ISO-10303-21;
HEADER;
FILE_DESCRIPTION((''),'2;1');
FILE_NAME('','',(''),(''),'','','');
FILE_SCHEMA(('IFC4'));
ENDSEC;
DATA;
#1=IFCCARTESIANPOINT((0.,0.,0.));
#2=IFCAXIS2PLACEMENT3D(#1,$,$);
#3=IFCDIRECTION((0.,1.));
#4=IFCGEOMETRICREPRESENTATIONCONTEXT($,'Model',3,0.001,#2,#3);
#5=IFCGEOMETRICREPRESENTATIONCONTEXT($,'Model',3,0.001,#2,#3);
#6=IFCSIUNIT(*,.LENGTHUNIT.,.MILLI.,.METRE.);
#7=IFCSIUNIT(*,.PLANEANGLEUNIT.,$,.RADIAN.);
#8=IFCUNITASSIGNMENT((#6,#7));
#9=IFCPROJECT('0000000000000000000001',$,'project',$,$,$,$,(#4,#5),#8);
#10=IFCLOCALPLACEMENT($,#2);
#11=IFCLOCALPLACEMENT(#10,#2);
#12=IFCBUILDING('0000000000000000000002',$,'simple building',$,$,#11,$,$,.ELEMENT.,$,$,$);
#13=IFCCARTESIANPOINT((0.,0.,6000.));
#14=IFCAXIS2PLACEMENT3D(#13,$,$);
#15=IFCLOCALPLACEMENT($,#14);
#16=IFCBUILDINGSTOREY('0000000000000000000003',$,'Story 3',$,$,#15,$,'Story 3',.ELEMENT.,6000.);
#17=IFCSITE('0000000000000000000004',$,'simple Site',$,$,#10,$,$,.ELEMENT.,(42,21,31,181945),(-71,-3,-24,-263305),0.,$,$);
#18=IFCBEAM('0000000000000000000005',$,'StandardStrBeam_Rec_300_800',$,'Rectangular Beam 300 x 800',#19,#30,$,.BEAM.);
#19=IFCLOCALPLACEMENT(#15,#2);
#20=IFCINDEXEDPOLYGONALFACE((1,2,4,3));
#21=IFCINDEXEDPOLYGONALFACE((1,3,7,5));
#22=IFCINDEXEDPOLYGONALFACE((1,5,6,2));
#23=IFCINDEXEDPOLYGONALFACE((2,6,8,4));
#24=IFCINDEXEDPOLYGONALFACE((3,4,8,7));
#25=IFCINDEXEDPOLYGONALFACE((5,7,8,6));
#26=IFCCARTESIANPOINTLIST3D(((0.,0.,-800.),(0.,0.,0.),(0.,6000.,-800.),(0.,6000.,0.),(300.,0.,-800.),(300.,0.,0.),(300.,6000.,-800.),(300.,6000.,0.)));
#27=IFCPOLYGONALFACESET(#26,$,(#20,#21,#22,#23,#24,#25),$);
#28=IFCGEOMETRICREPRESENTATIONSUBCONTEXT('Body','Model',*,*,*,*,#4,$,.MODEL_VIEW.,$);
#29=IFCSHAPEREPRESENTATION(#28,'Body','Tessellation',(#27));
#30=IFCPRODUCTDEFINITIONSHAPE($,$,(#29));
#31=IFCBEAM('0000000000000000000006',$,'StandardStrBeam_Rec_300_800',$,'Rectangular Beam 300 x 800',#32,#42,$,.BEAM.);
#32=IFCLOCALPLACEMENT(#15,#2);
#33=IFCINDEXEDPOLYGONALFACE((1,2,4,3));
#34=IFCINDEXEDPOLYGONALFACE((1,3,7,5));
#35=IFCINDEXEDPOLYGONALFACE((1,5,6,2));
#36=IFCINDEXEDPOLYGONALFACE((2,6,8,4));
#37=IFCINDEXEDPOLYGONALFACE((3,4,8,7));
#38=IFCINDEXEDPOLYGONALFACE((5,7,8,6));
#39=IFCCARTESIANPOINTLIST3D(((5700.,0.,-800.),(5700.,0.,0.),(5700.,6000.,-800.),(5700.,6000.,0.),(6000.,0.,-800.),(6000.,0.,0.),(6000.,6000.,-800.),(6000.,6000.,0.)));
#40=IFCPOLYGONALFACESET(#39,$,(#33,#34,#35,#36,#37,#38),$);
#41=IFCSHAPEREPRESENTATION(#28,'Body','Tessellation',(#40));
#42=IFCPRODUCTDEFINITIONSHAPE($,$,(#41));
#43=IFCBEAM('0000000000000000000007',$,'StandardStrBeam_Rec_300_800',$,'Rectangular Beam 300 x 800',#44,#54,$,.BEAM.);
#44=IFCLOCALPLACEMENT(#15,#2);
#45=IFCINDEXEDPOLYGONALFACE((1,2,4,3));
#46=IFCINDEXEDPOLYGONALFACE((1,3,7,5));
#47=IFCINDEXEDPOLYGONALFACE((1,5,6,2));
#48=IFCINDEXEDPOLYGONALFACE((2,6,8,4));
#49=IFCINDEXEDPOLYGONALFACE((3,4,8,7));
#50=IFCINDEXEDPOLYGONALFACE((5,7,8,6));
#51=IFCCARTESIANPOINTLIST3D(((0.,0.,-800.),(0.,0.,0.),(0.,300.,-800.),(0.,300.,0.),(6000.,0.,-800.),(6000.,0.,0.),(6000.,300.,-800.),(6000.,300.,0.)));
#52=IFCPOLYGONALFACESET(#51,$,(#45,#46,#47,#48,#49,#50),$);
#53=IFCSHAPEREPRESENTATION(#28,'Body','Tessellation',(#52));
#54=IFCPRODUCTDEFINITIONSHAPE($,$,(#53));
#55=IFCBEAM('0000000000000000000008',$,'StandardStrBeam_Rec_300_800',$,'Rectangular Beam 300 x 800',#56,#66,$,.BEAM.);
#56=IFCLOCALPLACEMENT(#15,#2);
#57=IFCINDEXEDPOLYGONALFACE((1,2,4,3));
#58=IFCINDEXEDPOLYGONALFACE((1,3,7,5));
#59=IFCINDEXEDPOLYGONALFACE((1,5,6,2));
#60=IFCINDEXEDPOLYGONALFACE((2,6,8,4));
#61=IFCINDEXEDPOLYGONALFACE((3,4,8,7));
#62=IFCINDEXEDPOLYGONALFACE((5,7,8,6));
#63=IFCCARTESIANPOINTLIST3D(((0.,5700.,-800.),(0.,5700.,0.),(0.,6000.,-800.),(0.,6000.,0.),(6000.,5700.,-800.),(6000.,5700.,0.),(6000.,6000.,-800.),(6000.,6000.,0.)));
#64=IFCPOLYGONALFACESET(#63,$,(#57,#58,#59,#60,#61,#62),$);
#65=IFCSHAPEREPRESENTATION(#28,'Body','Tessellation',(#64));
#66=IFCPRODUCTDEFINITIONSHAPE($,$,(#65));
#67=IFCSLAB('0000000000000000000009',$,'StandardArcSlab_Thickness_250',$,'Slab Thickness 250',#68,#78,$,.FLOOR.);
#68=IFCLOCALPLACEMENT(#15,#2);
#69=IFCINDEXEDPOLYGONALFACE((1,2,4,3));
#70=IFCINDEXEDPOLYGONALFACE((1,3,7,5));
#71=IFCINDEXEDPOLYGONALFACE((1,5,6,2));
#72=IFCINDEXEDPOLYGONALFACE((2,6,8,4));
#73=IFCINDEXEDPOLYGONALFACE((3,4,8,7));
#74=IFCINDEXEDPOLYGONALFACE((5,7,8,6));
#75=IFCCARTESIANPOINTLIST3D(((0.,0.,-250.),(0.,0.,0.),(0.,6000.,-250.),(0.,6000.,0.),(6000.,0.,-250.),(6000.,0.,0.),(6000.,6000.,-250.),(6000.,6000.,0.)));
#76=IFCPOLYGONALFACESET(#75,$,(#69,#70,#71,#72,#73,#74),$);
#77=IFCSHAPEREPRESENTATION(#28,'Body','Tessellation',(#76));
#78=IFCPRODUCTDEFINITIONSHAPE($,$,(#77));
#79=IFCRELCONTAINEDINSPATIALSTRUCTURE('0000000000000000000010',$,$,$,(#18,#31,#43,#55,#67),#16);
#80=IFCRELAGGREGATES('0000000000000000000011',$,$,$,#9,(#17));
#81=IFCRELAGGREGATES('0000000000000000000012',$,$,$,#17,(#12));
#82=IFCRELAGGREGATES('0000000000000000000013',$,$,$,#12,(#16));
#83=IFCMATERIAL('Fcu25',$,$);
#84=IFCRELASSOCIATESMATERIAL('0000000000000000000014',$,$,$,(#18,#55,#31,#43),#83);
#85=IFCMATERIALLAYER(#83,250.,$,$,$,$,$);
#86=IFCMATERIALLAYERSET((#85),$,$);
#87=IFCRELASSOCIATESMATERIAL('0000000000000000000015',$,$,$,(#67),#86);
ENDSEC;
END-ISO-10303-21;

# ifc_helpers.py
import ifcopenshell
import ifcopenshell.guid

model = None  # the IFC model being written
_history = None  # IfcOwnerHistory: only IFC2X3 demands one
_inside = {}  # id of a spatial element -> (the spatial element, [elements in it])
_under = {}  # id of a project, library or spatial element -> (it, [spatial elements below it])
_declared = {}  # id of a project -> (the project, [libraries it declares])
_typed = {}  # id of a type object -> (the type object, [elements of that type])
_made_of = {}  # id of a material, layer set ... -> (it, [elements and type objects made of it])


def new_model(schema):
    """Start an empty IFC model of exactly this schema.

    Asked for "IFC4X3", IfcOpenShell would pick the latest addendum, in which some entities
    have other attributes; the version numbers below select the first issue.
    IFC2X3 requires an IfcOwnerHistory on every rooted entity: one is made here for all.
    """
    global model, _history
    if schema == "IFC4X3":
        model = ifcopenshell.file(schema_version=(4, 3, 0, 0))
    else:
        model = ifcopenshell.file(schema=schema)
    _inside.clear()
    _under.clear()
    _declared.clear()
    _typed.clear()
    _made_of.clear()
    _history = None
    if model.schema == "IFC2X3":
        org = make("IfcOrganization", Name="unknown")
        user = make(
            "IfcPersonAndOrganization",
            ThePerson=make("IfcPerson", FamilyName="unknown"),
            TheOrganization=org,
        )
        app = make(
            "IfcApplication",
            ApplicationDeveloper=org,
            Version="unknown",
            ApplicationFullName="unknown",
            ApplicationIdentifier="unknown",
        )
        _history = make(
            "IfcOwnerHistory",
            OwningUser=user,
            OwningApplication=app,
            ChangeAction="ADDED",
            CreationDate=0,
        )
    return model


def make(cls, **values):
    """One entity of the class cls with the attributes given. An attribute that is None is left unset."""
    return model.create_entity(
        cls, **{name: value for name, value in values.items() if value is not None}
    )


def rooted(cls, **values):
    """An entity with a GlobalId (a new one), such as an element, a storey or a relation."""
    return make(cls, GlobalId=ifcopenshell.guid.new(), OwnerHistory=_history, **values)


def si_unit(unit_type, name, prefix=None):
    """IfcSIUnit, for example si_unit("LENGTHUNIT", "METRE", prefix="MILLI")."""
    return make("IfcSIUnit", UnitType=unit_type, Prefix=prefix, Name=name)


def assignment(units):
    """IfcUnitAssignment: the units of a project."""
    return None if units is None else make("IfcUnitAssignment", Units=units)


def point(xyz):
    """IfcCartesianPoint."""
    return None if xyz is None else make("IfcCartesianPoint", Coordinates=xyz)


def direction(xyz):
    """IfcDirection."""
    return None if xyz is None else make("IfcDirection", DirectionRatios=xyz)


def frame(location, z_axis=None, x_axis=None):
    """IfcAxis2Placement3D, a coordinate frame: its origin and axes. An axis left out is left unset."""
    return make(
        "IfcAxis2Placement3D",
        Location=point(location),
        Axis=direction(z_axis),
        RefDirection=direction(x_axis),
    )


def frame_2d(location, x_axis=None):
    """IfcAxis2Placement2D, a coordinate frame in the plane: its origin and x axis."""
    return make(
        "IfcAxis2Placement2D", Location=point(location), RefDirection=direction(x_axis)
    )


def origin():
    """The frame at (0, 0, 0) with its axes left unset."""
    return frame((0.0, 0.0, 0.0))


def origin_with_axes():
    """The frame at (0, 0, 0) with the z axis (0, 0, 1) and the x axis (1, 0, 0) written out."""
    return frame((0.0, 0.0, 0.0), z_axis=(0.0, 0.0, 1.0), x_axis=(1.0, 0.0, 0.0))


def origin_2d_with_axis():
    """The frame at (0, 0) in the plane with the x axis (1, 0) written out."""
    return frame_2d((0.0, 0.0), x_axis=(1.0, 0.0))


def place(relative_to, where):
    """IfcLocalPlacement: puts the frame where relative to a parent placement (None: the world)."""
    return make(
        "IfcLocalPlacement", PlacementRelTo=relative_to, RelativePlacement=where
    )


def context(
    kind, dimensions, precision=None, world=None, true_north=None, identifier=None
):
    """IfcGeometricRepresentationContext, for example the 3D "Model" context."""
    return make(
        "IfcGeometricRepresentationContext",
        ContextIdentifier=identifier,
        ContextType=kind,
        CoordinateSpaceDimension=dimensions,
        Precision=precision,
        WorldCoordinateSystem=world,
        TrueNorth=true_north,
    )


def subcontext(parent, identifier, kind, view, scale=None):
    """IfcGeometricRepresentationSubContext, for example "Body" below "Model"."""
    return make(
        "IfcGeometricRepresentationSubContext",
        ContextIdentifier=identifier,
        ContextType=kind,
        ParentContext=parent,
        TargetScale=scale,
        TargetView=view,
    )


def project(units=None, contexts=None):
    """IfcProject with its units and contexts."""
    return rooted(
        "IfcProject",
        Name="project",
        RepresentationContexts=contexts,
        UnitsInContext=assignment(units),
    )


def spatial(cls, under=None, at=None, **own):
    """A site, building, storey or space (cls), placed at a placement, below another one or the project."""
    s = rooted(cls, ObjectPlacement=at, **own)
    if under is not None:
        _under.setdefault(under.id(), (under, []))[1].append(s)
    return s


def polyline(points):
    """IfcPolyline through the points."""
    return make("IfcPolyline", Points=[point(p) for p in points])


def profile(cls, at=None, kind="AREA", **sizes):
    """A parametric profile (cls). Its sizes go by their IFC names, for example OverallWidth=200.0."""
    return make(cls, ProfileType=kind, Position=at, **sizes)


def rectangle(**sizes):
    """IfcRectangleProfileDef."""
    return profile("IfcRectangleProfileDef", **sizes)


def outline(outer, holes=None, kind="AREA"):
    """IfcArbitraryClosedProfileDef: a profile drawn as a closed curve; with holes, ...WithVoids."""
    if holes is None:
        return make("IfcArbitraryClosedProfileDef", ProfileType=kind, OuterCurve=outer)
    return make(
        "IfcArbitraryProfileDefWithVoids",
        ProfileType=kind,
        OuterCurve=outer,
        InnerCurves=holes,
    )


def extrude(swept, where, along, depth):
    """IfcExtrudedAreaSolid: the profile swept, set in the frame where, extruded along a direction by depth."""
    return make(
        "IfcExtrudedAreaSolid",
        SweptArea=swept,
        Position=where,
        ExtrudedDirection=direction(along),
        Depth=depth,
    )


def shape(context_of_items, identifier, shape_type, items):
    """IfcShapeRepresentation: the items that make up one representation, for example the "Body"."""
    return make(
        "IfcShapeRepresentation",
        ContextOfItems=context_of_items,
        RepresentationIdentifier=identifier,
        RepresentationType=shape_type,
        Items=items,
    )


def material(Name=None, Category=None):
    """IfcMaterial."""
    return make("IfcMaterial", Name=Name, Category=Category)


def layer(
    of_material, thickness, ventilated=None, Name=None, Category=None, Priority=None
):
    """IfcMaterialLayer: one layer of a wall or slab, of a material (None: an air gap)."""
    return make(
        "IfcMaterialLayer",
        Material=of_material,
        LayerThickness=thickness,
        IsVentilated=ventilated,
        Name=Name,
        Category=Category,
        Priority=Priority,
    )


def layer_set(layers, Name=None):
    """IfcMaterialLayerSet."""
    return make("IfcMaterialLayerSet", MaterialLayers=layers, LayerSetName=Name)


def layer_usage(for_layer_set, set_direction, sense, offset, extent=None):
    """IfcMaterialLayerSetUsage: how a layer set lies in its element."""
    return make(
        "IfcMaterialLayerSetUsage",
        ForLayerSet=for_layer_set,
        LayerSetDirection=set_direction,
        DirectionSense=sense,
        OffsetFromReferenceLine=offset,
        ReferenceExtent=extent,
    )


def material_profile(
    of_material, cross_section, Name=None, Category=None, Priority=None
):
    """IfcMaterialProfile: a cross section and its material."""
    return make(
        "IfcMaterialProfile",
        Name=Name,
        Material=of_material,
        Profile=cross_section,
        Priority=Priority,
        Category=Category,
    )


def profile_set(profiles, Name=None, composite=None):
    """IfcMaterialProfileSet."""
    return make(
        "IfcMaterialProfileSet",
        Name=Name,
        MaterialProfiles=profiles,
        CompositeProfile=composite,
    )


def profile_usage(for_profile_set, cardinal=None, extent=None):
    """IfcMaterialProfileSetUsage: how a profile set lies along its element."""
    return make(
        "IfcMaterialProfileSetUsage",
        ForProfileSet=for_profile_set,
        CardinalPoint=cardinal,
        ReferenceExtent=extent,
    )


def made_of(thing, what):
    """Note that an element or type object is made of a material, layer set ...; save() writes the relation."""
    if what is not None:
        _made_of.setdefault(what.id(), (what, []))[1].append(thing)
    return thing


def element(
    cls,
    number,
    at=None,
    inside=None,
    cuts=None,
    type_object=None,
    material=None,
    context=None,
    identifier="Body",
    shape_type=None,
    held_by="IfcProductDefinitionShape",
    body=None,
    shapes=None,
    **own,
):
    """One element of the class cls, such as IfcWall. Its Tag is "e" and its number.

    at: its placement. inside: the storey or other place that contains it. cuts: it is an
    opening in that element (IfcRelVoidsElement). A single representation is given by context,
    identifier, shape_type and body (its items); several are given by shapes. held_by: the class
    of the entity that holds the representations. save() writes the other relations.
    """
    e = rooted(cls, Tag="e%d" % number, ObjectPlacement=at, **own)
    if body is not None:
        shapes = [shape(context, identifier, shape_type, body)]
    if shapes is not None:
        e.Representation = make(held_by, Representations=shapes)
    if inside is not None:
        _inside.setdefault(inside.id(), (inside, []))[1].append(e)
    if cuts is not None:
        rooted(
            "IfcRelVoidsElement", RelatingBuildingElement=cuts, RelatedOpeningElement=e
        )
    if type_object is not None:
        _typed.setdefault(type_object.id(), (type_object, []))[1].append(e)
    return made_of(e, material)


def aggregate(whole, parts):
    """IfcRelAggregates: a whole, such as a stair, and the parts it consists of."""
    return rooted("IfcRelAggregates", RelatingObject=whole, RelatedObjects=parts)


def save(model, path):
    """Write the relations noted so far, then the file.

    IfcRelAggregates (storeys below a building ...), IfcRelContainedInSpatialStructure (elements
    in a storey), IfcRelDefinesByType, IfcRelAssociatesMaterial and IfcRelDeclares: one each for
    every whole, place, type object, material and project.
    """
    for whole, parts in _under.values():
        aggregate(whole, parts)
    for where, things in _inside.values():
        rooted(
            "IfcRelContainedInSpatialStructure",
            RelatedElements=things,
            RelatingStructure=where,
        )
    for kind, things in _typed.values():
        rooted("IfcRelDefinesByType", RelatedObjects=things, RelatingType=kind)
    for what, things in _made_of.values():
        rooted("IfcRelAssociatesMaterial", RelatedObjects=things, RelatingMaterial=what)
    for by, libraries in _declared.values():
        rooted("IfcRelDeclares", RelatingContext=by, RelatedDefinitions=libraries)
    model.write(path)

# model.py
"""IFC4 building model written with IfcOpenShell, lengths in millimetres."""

from ifc_helpers import new_model, si_unit, direction, frame, origin, origin_with_axes, origin_2d_with_axis, place, context, subcontext, project, spatial, polyline, rectangle, outline, extrude, material, layer, layer_set, layer_usage, material_profile, profile_set, profile_usage, element, save


model = new_model("IFC4")

# Units and contexts
model_context_1 = context("Model", 3, precision=0.001, world=origin(), true_north=direction((0.0, 1.0)))
model_context_2 = context("Model", 3, precision=0.001, world=origin(), true_north=direction((0.0, 1.0)))
body_context = subcontext(model_context_1, "Body", "Model", "MODEL_VIEW")
ifc_project = project(units=[si_unit("LENGTHUNIT", "METRE", prefix="MILLI"), si_unit("PLANEANGLEUNIT", "RADIAN")], contexts=[model_context_1, model_context_2])

# Site, building, storey
site_placement = place(None, origin())
site = spatial("IfcSite", under=ifc_project, at=site_placement, Name="simple Site", CompositionType="ELEMENT", RefLatitude=(42, 21, 31, 181945), RefLongitude=(-71, -3, -24, -263305), RefElevation=0.0)
building_placement = place(site_placement, origin())
building = spatial("IfcBuilding", under=site, at=building_placement, Name="simple building", CompositionType="ELEMENT")
storey_placement = place(None, frame((0.0, 0.0, 6000.0)))
storey = spatial("IfcBuildingStorey", under=building, at=storey_placement, Name="Story 3", LongName="Story 3", CompositionType="ELEMENT", Elevation=6000.0)

# Beams
ifc_material = material(Name="Fcu25")
ifc_material_profile = material_profile(ifc_material, rectangle(XDim=300.0, YDim=800.0, at=origin_2d_with_axis()))
ifc_profile_set = profile_set([ifc_material_profile])
ifc_profile_usage_1 = profile_usage(ifc_profile_set, cardinal=7)
beam_1_placement = place(None, frame((150.0, 0.0, 5600.0), z_axis=(0.0, 1.0, 0.0), x_axis=(1.0, 0.0, 0.0)))
element("IfcBeam", 1, at=beam_1_placement, inside=storey, material=ifc_profile_usage_1, Name="StandardStrBeam_Rec_300_800", ObjectType="Rectangular Beam 300 x 800", PredefinedType="BEAM", context=body_context, shape_type="SweptSolid", body=[
    extrude(rectangle(XDim=300.0, YDim=800.0, at=origin_2d_with_axis()), origin_with_axes(), (0.0, 0.0, 1.0), 6000.0),
])
ifc_profile_usage_2 = profile_usage(ifc_profile_set, cardinal=9)
for number, where, z_axis, x_axis, name in (
    (2, (5850.0, 0.0, 5600.0), (0.0, 1.0, 0.0), (1.0, 0.0, 0.0), "StandardStrBeam_Rec_300_800"),
    (3, (0.0, 150.0, 5600.0), (1.0, 0.0, 0.0), (0.0, -1.0, 0.0), "StandardStrBeam_Rec_300_800"),
):
    element("IfcBeam", number, at=place(None, frame(where, z_axis=z_axis, x_axis=x_axis)), inside=storey, material=ifc_profile_usage_2, Name=name, ObjectType="Rectangular Beam 300 x 800", PredefinedType="BEAM", context=body_context, shape_type="SweptSolid", body=[
        extrude(rectangle(XDim=300.0, YDim=800.0, at=origin_2d_with_axis()), origin_with_axes(), (0.0, 0.0, 1.0), 6000.0),
    ])
beam_2_placement = place(None, frame((0.0, 5850.0, 5600.0), z_axis=(1.0, 0.0, 0.0), x_axis=(0.0, -1.0, 0.0)))
element("IfcBeam", 4, at=beam_2_placement, inside=storey, material=ifc_profile_usage_1, Name="StandardStrBeam_Rec_300_800", ObjectType="Rectangular Beam 300 x 800", PredefinedType="BEAM", context=body_context, shape_type="SweptSolid", body=[
    extrude(rectangle(XDim=300.0, YDim=800.0, at=origin_2d_with_axis()), origin_with_axes(), (0.0, 0.0, 1.0), 6000.0),
])

# Slab
ifc_layer = layer(ifc_material, 250.0)
ifc_layer_set = layer_set([ifc_layer])
ifc_layer_usage = layer_usage(ifc_layer_set, "AXIS3", "POSITIVE", -250.0)
slab_placement = place(None, frame((0.0, 0.0, 5750.0), z_axis=(0.0, 0.0, 1.0), x_axis=(1.0, 0.0, 0.0)))
element("IfcSlab", 5, at=slab_placement, inside=storey, material=ifc_layer_usage, Name="StandardArcSlab_Thickness_250", ObjectType="Slab Thickness 250", PredefinedType="FLOOR", context=body_context, shape_type="SweptSolid", body=[
    extrude(outline(polyline([(0.0, 0.0), (6000.0, 0.0), (6000.0, 6000.0), (0.0, 6000.0), (0.0, 0.0)])), origin_with_axes(), (0.0, 0.0, 1.0), 250.0),
])

save(model, "model.ifc")
